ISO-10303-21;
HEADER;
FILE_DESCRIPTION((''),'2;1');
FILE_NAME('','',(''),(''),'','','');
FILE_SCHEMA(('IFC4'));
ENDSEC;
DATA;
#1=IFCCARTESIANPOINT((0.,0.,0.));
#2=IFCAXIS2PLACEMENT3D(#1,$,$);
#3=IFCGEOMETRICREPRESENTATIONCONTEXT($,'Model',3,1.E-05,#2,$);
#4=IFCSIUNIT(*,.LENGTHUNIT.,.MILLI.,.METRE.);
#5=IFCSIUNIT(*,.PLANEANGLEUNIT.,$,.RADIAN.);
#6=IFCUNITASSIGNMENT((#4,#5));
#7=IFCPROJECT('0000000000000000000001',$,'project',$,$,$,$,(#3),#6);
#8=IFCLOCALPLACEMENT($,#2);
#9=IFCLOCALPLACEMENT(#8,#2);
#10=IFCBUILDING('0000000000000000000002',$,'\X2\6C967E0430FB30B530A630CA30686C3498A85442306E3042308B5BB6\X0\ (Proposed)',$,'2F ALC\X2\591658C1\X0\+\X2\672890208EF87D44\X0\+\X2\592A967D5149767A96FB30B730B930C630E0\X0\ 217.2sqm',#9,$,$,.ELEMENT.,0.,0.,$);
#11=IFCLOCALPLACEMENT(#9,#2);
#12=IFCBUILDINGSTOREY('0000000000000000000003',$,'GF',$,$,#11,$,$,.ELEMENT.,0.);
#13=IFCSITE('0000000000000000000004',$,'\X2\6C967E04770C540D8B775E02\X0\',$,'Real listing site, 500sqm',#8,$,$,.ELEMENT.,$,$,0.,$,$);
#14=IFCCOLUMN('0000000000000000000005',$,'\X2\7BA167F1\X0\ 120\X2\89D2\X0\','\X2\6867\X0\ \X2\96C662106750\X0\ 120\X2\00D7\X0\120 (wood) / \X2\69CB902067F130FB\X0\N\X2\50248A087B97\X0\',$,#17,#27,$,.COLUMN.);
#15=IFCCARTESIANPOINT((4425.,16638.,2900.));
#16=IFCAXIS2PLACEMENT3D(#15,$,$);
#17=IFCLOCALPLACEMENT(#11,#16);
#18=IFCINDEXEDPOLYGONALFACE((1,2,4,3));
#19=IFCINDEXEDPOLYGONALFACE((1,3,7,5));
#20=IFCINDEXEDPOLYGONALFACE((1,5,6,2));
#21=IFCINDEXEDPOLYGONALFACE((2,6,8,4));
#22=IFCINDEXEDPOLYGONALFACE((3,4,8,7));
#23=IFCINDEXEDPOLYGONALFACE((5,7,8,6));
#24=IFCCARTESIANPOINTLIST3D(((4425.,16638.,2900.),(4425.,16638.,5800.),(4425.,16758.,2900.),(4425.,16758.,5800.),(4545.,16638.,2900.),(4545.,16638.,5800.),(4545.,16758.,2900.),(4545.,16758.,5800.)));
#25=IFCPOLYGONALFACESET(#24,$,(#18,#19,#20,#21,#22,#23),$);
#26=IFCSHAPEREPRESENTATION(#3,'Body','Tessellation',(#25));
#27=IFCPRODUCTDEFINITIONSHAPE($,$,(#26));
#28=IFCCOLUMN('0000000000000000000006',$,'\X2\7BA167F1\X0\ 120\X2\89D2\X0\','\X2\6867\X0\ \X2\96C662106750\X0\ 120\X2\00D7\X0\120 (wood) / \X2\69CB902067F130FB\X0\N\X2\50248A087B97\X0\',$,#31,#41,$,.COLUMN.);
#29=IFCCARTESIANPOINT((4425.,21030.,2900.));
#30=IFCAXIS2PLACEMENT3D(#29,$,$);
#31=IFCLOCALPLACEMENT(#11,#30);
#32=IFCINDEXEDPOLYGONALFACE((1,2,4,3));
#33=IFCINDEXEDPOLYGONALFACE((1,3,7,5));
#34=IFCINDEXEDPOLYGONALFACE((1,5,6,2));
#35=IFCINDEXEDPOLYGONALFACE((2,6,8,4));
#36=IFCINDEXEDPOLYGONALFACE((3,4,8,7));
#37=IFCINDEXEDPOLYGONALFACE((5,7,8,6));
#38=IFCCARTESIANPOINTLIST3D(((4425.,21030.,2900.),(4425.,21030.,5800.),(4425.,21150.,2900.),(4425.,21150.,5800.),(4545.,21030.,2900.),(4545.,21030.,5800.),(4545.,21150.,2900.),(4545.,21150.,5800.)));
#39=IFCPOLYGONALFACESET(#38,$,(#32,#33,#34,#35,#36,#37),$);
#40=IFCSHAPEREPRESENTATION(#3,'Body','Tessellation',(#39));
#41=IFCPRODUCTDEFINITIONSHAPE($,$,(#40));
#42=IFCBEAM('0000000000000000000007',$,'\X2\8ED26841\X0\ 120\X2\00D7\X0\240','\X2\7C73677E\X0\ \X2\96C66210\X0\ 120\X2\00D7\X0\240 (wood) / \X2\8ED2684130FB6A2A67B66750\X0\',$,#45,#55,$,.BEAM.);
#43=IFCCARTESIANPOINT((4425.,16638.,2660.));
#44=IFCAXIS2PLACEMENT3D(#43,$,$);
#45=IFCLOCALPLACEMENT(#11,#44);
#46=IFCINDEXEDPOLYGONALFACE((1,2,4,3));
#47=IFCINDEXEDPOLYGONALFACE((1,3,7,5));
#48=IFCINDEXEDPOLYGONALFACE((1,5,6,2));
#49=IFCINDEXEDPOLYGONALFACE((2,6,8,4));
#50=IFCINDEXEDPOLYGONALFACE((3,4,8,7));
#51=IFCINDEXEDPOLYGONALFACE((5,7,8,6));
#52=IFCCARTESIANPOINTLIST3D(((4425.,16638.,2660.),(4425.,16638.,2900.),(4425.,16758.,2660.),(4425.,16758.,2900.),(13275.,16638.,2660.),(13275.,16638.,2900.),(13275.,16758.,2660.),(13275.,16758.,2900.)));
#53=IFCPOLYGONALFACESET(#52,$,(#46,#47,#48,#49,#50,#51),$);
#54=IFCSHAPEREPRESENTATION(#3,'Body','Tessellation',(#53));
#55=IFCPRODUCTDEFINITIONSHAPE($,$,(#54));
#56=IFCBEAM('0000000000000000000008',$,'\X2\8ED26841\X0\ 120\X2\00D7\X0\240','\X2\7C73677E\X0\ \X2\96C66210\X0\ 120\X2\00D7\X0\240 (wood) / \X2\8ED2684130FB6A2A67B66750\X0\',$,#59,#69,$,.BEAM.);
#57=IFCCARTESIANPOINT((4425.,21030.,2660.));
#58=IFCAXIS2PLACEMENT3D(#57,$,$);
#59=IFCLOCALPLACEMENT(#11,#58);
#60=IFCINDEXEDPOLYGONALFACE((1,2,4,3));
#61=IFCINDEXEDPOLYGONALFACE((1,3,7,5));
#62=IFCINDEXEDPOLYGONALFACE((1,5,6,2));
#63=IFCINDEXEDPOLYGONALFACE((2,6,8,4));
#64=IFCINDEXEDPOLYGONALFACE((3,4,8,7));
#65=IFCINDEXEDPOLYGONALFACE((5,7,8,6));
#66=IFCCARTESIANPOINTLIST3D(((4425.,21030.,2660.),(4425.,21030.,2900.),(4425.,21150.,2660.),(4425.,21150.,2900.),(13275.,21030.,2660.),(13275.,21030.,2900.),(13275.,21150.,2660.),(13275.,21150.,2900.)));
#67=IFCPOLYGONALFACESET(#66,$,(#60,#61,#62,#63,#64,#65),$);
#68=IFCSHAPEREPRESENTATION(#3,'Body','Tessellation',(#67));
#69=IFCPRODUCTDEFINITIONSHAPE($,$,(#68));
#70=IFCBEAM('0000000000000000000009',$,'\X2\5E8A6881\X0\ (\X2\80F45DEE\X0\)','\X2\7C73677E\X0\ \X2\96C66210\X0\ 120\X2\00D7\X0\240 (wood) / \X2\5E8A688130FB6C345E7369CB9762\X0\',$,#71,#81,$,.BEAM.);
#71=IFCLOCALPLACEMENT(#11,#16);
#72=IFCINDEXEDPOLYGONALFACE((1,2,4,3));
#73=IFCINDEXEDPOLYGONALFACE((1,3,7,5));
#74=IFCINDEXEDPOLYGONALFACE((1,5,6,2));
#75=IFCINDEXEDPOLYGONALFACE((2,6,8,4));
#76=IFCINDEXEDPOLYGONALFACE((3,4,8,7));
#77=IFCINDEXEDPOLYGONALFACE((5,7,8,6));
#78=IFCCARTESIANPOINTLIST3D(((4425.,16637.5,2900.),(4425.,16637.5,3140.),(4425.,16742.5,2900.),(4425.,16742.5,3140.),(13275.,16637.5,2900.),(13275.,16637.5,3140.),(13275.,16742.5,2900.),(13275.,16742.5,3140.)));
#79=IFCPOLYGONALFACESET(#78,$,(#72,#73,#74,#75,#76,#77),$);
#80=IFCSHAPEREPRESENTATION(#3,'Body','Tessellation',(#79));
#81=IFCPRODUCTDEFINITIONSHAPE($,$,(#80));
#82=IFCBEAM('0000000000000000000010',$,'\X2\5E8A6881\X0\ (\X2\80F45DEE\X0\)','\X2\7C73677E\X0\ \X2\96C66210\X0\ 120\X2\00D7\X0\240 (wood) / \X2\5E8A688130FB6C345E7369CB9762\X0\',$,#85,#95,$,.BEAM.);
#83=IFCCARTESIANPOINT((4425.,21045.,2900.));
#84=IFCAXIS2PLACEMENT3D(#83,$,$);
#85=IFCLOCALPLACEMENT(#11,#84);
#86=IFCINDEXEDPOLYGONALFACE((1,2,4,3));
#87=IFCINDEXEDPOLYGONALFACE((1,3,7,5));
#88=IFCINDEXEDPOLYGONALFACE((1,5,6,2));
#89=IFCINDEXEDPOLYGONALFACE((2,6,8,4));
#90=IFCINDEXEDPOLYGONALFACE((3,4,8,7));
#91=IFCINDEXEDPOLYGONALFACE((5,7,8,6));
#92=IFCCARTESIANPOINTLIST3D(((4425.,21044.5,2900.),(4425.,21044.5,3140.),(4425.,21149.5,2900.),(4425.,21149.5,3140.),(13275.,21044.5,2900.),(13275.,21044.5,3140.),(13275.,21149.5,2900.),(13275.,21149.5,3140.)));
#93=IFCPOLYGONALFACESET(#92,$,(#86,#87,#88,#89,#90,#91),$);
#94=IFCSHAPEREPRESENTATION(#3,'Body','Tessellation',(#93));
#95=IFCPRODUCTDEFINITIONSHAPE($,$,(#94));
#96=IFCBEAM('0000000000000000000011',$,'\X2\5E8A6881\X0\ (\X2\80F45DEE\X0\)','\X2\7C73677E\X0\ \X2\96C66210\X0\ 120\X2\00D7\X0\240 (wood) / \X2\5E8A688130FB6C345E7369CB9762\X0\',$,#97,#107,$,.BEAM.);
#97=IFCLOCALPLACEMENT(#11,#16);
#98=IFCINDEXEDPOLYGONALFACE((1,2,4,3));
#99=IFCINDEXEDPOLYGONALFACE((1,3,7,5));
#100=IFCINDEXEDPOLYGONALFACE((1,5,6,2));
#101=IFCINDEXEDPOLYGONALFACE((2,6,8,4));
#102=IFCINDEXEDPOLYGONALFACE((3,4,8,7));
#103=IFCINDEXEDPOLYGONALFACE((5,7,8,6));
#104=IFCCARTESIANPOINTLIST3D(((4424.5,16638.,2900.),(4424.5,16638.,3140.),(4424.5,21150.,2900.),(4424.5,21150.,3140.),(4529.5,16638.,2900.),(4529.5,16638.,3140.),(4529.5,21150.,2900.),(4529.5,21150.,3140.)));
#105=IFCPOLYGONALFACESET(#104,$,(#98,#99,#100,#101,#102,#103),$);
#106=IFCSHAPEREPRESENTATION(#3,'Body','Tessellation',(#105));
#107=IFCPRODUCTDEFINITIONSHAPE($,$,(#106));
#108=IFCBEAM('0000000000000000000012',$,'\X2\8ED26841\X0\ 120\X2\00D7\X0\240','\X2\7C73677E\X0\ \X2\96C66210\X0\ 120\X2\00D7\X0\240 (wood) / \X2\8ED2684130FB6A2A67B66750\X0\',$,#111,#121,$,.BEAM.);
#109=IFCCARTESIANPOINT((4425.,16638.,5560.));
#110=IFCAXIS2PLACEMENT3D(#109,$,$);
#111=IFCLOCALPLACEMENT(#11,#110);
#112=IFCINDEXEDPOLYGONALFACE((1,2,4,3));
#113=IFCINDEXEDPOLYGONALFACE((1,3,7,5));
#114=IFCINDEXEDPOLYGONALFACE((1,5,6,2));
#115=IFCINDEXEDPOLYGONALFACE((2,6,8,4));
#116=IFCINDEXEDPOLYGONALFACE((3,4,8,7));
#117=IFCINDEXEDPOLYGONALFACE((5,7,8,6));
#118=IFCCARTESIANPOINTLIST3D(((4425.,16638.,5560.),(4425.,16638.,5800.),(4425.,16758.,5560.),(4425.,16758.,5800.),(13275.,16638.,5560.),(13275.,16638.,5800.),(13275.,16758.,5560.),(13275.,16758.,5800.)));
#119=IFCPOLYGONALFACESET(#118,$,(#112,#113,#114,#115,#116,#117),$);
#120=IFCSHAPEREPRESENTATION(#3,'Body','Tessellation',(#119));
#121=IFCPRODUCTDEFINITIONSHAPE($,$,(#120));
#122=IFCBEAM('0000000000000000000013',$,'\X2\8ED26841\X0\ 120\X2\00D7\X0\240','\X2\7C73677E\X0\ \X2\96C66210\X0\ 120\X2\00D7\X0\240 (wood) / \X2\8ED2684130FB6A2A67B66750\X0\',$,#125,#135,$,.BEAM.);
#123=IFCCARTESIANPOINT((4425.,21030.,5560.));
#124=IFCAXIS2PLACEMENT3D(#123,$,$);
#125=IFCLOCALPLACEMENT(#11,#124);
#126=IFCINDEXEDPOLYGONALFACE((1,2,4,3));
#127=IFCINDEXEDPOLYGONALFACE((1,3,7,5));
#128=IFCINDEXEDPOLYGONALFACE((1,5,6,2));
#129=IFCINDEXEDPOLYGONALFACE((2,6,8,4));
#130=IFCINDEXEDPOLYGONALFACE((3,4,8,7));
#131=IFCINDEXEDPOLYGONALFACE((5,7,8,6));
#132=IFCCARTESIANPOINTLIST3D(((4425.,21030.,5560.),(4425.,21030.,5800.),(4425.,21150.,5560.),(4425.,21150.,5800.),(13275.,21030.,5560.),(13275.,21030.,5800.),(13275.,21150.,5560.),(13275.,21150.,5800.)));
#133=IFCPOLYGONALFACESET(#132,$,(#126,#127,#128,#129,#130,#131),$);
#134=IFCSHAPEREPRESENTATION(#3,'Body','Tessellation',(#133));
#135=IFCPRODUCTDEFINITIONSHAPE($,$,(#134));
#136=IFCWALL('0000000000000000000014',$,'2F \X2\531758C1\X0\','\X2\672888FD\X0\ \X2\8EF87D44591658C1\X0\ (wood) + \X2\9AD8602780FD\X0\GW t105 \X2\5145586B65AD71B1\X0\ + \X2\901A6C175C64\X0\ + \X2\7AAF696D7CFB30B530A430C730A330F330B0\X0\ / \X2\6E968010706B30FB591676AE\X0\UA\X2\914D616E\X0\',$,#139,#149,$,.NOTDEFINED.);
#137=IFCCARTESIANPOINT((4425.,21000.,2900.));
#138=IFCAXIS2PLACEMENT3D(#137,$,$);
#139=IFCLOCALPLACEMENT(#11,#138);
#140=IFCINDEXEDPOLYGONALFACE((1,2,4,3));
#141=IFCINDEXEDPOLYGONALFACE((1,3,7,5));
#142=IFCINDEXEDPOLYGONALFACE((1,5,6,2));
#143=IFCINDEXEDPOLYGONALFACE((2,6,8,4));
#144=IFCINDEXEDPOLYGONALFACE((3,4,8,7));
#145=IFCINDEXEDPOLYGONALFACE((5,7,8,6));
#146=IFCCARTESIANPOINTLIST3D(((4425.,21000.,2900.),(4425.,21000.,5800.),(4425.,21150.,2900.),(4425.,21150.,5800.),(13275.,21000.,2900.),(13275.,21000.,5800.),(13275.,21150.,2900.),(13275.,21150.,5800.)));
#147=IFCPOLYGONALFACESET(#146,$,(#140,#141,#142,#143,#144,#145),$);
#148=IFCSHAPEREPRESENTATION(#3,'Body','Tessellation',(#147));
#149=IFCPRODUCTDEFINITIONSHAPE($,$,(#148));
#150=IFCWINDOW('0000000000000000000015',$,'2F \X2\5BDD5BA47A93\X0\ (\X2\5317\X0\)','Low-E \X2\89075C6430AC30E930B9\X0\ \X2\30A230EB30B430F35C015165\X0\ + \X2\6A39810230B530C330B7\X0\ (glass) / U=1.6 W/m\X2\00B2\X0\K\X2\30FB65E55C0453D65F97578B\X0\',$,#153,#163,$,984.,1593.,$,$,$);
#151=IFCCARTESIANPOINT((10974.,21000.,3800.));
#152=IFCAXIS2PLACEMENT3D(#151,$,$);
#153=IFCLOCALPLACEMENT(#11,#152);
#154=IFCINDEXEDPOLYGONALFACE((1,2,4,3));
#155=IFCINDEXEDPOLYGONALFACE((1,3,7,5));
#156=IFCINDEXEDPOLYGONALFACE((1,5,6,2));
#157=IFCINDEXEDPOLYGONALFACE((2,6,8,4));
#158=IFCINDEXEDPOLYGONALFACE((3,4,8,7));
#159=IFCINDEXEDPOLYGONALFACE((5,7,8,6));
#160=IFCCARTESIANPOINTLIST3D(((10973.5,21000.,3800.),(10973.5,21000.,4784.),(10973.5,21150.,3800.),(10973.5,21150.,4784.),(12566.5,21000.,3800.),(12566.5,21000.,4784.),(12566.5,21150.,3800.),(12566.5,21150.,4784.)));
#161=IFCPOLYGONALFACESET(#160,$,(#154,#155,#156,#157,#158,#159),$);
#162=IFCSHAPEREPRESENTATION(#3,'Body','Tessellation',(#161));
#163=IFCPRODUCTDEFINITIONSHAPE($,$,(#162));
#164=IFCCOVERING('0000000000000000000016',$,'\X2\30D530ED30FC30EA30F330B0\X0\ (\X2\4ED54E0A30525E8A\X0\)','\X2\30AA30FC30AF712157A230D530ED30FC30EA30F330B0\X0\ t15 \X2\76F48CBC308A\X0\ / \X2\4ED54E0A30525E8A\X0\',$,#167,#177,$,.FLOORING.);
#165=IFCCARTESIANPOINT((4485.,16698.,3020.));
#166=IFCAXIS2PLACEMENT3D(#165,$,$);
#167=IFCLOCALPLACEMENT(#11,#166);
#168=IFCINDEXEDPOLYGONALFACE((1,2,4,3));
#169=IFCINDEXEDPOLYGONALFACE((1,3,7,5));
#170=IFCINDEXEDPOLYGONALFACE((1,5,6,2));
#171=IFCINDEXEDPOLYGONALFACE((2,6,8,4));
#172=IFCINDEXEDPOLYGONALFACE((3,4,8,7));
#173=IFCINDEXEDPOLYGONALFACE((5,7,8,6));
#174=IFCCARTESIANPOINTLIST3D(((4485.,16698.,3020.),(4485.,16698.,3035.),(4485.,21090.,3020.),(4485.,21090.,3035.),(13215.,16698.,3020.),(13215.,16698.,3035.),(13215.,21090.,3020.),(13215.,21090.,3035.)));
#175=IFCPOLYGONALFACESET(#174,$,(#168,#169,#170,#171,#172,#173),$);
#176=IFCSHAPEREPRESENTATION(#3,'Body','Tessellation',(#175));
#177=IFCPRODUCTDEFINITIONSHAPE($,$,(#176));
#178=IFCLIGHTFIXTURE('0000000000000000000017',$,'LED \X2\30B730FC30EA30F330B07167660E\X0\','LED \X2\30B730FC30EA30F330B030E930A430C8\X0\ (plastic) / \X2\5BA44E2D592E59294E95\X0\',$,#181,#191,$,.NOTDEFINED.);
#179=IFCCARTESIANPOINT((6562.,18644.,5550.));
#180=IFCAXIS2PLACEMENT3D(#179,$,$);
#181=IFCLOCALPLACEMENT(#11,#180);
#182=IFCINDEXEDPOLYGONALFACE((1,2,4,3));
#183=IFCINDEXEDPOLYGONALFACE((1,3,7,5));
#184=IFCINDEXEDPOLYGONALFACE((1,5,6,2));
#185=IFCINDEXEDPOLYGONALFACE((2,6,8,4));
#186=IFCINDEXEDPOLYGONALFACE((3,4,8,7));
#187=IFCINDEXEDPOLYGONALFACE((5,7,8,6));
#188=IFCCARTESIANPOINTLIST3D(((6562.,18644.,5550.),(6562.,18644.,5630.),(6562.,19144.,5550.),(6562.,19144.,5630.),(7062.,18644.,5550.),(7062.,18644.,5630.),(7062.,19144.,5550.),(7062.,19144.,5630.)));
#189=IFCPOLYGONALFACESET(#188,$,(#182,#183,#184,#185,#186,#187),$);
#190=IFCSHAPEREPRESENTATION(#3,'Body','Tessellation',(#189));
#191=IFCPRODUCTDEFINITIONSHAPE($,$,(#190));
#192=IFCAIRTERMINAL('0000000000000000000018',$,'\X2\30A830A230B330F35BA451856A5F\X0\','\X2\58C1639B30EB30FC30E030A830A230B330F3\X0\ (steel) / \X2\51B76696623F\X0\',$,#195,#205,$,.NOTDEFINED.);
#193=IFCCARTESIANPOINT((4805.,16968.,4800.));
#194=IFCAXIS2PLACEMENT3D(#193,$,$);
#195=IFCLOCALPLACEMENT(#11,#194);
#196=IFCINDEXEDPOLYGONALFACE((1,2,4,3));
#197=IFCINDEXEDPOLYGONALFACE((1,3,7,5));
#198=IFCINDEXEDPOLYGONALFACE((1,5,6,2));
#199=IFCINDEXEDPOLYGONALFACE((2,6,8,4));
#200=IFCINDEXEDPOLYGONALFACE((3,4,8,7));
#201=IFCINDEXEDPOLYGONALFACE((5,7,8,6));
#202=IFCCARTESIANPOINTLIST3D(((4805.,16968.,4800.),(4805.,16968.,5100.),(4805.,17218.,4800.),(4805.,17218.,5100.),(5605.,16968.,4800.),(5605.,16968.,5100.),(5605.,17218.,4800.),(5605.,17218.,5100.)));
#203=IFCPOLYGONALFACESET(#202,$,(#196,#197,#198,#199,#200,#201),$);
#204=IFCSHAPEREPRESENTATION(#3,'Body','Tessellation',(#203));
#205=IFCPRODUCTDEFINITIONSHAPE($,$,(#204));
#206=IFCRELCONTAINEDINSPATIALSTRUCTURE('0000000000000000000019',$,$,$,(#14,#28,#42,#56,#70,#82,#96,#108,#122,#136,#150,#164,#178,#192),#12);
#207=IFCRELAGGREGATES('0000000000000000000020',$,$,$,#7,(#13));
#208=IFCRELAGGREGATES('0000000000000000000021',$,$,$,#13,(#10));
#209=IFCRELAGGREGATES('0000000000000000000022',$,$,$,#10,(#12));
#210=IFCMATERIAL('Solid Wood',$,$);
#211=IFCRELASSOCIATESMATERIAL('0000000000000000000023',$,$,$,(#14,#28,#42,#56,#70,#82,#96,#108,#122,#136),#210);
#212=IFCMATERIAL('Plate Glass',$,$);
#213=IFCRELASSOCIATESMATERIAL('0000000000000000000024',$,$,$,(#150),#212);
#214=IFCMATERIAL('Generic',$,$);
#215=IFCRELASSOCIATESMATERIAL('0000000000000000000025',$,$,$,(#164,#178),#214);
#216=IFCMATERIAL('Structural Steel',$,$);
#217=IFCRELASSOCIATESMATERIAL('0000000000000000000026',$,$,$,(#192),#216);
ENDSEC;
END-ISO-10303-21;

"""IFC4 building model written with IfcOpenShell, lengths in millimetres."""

from ifc_helpers import new_model, si_unit, frame, frame_2d, origin, place, context, project, spatial, rectangle, extrude, material, element, fill, save


model = new_model("IFC4")

# Units and contexts
model_context = context("Model", 3, precision=1e-05, world=origin())
ifc_project = project(units=[si_unit("LENGTHUNIT", "METRE", prefix="MILLI"), si_unit("PLANEANGLEUNIT", "RADIAN")], contexts=[model_context])

# Site, building, storey
site_placement = place(None, origin())
site = spatial("IfcSite", under=ifc_project, at=site_placement, Name="沖縄県名護市", ObjectType="Real listing site, 500sqm", CompositionType="ELEMENT", RefElevation=0.0)
building_placement = place(site_placement, origin())
building = spatial("IfcBuilding", under=site, at=building_placement, Name="沖縄・サウナと水風呂のある家 (Proposed)", ObjectType="2F ALC外壁+木造軸組+太陽光発電システム 217.2sqm", CompositionType="ELEMENT", ElevationOfRefHeight=0.0, ElevationOfTerrain=0.0)
storey_placement = place(building_placement, origin())
storey = spatial("IfcBuildingStorey", under=building, at=storey_placement, Name="GF", CompositionType="ELEMENT", Elevation=0.0)

# Columns
ifc_material_1 = material(Name="Solid Wood")
column_1_placement = place(storey_placement, frame((4425.0, 16638.0, 2900.0)))
element("IfcColumn", 1, at=column_1_placement, inside=storey, material=ifc_material_1, Name="管柱 120角", Description="桧 集成材 120×120 (wood) / 構造柱・N値計算", PredefinedType="COLUMN", context=model_context, shape_type="SweptSolid", body=[
    extrude(rectangle(XDim=120.0, YDim=120.0, at=frame_2d((60.0, 60.0))), frame((4425.0, 16638.0, 2900.0)), (0.0, 0.0, 1.0), 2900.0),
])
column_2_placement = place(storey_placement, frame((4425.0, 21030.0, 2900.0)))
element("IfcColumn", 2, at=column_2_placement, inside=storey, material=ifc_material_1, Name="管柱 120角", Description="桧 集成材 120×120 (wood) / 構造柱・N値計算", PredefinedType="COLUMN", context=model_context, shape_type="SweptSolid", body=[
    extrude(rectangle(XDim=120.0, YDim=120.0, at=frame_2d((60.0, 60.0))), frame((4425.0, 21030.0, 2900.0)), (0.0, 0.0, 1.0), 2900.0),
])

# Beams
beam_1_placement = place(storey_placement, frame((4425.0, 16638.0, 2660.0)))
element("IfcBeam", 3, at=beam_1_placement, inside=storey, material=ifc_material_1, Name="軒桁 120×240", Description="米松 集成 120×240 (wood) / 軒桁・横架材", PredefinedType="BEAM", context=model_context, shape_type="SweptSolid", body=[
    extrude(rectangle(XDim=8850.0, YDim=120.0, at=frame_2d((4425.0, 60.0))), frame((4425.0, 16638.0, 2660.0)), (0.0, 0.0, 1.0), 240.0),
])
beam_2_placement = place(storey_placement, frame((4425.0, 21030.0, 2660.0)))
element("IfcBeam", 4, at=beam_2_placement, inside=storey, material=ifc_material_1, Name="軒桁 120×240", Description="米松 集成 120×240 (wood) / 軒桁・横架材", PredefinedType="BEAM", context=model_context, shape_type="SweptSolid", body=[
    extrude(rectangle(XDim=8850.0, YDim=120.0, at=frame_2d((4425.0, 60.0))), frame((4425.0, 21030.0, 2660.0)), (0.0, 0.0, 1.0), 240.0),
])
beam_3_placement = place(storey_placement, frame((4425.0, 16638.0, 2900.0)))
element("IfcBeam", 5, at=beam_3_placement, inside=storey, material=ifc_material_1, Name="床梁 (胴差)", Description="米松 集成 120×240 (wood) / 床梁・水平構面", PredefinedType="BEAM", context=model_context, shape_type="SweptSolid", body=[
    extrude(rectangle(XDim=8850.0, YDim=105.0, at=frame_2d((4425.0, 52.0))), frame((4425.0, 16638.0, 2900.0)), (0.0, 0.0, 1.0), 240.0),
])
beam_4_placement = place(storey_placement, frame((4425.0, 21045.0, 2900.0)))
element("IfcBeam", 6, at=beam_4_placement, inside=storey, material=ifc_material_1, Name="床梁 (胴差)", Description="米松 集成 120×240 (wood) / 床梁・水平構面", PredefinedType="BEAM", context=model_context, shape_type="SweptSolid", body=[
    extrude(rectangle(XDim=8850.0, YDim=105.0, at=frame_2d((4425.0, 52.0))), frame((4425.0, 21045.0, 2900.0)), (0.0, 0.0, 1.0), 240.0),
])
beam_5_placement = place(storey_placement, frame((4425.0, 16638.0, 2900.0)))
element("IfcBeam", 7, at=beam_5_placement, inside=storey, material=ifc_material_1, Name="床梁 (胴差)", Description="米松 集成 120×240 (wood) / 床梁・水平構面", PredefinedType="BEAM", context=model_context, shape_type="SweptSolid", body=[
    extrude(rectangle(XDim=105.0, YDim=4512.0, at=frame_2d((52.0, 2256.0))), frame((4425.0, 16638.0, 2900.0)), (0.0, 0.0, 1.0), 240.0),
])
beam_6_placement = place(storey_placement, frame((4425.0, 16638.0, 5560.0)))
element("IfcBeam", 8, at=beam_6_placement, inside=storey, material=ifc_material_1, Name="軒桁 120×240", Description="米松 集成 120×240 (wood) / 軒桁・横架材", PredefinedType="BEAM", context=model_context, shape_type="SweptSolid", body=[
    extrude(rectangle(XDim=8850.0, YDim=120.0, at=frame_2d((4425.0, 60.0))), frame((4425.0, 16638.0, 5560.0)), (0.0, 0.0, 1.0), 240.0),
])
beam_7_placement = place(storey_placement, frame((4425.0, 21030.0, 5560.0)))
element("IfcBeam", 9, at=beam_7_placement, inside=storey, material=ifc_material_1, Name="軒桁 120×240", Description="米松 集成 120×240 (wood) / 軒桁・横架材", PredefinedType="BEAM", context=model_context, shape_type="SweptSolid", body=[
    extrude(rectangle(XDim=8850.0, YDim=120.0, at=frame_2d((4425.0, 60.0))), frame((4425.0, 21030.0, 5560.0)), (0.0, 0.0, 1.0), 240.0),
])

# Wall, opening, window
wall_placement = place(storey_placement, frame((4425.0, 21000.0, 2900.0)))
wall = element("IfcWall", 10, at=wall_placement, inside=storey, material=ifc_material_1, Name="2F 北壁", Description="木製 軸組外壁 (wood) + 高性能GW t105 充填断熱 + 通気層 + 窯業系サイディング / 準耐火・外皮UA配慮", PredefinedType="NOTDEFINED", context=model_context, shape_type="SweptSolid", body=[
    extrude(rectangle(XDim=8850.0, YDim=150.0, at=frame_2d((4425.0, 75.0))), frame((4425.0, 21000.0, 2900.0)), (0.0, 0.0, 1.0), 2900.0),
])
opening_placement = place(storey_placement, frame((10974.0, 21000.0, 3800.0)))
opening = element("IfcOpeningElement", 11, at=opening_placement, cuts=wall, PredefinedType="NOTDEFINED", context=model_context, shape_type="SweptSolid", body=[
    extrude(rectangle(XDim=1593.0, YDim=150.0, at=frame_2d((796.0, 75.0))), frame((10974.0, 21000.0, 3800.0)), (0.0, 0.0, 1.0), 984.0),
])
ifc_material_2 = material(Name="Plate Glass")
window_placement = place(storey_placement, frame((10974.0, 21000.0, 3800.0)))
window = element("IfcWindow", 12, at=window_placement, inside=storey, material=ifc_material_2, Name="2F 寝室窓 (北)", Description="Low-E 複層ガラス アルゴン封入 + 樹脂サッシ (glass) / U=1.6 W/m²K・日射取得型", OverallHeight=984.0, OverallWidth=1593.0, context=model_context, shape_type="SweptSolid", body=[
    extrude(rectangle(XDim=1593.0, YDim=150.0, at=frame_2d((796.0, 75.0))), frame((10974.0, 21000.0, 3800.0)), (0.0, 0.0, 1.0), 984.0),
])
fill(opening, window)

# Covering
ifc_material_3 = material(Name="Generic")
covering_placement = place(storey_placement, frame((4485.0, 16698.0, 3020.0)))
element("IfcCovering", 13, at=covering_placement, inside=storey, material=ifc_material_3, Name="フローリング (仕上げ床)", Description="オーク無垢フローリング t15 直貼り / 仕上げ床", PredefinedType="FLOORING", context=model_context, shape_type="SweptSolid", body=[
    extrude(rectangle(XDim=8730.0, YDim=4392.0, at=frame_2d((4365.0, 2196.0))), frame((4485.0, 16698.0, 3020.0)), (0.0, 0.0, 1.0), 15.0),
])

# Light fixture
light_fixture_placement = place(storey_placement, frame((6562.0, 18644.0, 5550.0)))
element("IfcLightFixture", 14, at=light_fixture_placement, inside=storey, material=ifc_material_3, Name="LED シーリング照明", Description="LED シーリングライト (plastic) / 室中央天井", PredefinedType="NOTDEFINED", context=model_context, shape_type="SweptSolid", body=[
    extrude(rectangle(XDim=500.0, YDim=500.0, at=frame_2d((250.0, 250.0))), frame((6562.0, 18644.0, 5550.0)), (0.0, 0.0, 1.0), 80.0),
])

# Air terminal
ifc_material_4 = material(Name="Structural Steel")
air_terminal_placement = place(storey_placement, frame((4805.0, 16968.0, 4800.0)))
element("IfcAirTerminal", 15, at=air_terminal_placement, inside=storey, material=ifc_material_4, Name="エアコン室内機", Description="壁掛ルームエアコン (steel) / 冷暖房", PredefinedType="NOTDEFINED", context=model_context, shape_type="SweptSolid", body=[
    extrude(rectangle(XDim=800.0, YDim=250.0, at=frame_2d((400.0, 125.0))), frame((4805.0, 16968.0, 4800.0)), (0.0, 0.0, 1.0), 300.0),
])

save(model, "model.ifc")
